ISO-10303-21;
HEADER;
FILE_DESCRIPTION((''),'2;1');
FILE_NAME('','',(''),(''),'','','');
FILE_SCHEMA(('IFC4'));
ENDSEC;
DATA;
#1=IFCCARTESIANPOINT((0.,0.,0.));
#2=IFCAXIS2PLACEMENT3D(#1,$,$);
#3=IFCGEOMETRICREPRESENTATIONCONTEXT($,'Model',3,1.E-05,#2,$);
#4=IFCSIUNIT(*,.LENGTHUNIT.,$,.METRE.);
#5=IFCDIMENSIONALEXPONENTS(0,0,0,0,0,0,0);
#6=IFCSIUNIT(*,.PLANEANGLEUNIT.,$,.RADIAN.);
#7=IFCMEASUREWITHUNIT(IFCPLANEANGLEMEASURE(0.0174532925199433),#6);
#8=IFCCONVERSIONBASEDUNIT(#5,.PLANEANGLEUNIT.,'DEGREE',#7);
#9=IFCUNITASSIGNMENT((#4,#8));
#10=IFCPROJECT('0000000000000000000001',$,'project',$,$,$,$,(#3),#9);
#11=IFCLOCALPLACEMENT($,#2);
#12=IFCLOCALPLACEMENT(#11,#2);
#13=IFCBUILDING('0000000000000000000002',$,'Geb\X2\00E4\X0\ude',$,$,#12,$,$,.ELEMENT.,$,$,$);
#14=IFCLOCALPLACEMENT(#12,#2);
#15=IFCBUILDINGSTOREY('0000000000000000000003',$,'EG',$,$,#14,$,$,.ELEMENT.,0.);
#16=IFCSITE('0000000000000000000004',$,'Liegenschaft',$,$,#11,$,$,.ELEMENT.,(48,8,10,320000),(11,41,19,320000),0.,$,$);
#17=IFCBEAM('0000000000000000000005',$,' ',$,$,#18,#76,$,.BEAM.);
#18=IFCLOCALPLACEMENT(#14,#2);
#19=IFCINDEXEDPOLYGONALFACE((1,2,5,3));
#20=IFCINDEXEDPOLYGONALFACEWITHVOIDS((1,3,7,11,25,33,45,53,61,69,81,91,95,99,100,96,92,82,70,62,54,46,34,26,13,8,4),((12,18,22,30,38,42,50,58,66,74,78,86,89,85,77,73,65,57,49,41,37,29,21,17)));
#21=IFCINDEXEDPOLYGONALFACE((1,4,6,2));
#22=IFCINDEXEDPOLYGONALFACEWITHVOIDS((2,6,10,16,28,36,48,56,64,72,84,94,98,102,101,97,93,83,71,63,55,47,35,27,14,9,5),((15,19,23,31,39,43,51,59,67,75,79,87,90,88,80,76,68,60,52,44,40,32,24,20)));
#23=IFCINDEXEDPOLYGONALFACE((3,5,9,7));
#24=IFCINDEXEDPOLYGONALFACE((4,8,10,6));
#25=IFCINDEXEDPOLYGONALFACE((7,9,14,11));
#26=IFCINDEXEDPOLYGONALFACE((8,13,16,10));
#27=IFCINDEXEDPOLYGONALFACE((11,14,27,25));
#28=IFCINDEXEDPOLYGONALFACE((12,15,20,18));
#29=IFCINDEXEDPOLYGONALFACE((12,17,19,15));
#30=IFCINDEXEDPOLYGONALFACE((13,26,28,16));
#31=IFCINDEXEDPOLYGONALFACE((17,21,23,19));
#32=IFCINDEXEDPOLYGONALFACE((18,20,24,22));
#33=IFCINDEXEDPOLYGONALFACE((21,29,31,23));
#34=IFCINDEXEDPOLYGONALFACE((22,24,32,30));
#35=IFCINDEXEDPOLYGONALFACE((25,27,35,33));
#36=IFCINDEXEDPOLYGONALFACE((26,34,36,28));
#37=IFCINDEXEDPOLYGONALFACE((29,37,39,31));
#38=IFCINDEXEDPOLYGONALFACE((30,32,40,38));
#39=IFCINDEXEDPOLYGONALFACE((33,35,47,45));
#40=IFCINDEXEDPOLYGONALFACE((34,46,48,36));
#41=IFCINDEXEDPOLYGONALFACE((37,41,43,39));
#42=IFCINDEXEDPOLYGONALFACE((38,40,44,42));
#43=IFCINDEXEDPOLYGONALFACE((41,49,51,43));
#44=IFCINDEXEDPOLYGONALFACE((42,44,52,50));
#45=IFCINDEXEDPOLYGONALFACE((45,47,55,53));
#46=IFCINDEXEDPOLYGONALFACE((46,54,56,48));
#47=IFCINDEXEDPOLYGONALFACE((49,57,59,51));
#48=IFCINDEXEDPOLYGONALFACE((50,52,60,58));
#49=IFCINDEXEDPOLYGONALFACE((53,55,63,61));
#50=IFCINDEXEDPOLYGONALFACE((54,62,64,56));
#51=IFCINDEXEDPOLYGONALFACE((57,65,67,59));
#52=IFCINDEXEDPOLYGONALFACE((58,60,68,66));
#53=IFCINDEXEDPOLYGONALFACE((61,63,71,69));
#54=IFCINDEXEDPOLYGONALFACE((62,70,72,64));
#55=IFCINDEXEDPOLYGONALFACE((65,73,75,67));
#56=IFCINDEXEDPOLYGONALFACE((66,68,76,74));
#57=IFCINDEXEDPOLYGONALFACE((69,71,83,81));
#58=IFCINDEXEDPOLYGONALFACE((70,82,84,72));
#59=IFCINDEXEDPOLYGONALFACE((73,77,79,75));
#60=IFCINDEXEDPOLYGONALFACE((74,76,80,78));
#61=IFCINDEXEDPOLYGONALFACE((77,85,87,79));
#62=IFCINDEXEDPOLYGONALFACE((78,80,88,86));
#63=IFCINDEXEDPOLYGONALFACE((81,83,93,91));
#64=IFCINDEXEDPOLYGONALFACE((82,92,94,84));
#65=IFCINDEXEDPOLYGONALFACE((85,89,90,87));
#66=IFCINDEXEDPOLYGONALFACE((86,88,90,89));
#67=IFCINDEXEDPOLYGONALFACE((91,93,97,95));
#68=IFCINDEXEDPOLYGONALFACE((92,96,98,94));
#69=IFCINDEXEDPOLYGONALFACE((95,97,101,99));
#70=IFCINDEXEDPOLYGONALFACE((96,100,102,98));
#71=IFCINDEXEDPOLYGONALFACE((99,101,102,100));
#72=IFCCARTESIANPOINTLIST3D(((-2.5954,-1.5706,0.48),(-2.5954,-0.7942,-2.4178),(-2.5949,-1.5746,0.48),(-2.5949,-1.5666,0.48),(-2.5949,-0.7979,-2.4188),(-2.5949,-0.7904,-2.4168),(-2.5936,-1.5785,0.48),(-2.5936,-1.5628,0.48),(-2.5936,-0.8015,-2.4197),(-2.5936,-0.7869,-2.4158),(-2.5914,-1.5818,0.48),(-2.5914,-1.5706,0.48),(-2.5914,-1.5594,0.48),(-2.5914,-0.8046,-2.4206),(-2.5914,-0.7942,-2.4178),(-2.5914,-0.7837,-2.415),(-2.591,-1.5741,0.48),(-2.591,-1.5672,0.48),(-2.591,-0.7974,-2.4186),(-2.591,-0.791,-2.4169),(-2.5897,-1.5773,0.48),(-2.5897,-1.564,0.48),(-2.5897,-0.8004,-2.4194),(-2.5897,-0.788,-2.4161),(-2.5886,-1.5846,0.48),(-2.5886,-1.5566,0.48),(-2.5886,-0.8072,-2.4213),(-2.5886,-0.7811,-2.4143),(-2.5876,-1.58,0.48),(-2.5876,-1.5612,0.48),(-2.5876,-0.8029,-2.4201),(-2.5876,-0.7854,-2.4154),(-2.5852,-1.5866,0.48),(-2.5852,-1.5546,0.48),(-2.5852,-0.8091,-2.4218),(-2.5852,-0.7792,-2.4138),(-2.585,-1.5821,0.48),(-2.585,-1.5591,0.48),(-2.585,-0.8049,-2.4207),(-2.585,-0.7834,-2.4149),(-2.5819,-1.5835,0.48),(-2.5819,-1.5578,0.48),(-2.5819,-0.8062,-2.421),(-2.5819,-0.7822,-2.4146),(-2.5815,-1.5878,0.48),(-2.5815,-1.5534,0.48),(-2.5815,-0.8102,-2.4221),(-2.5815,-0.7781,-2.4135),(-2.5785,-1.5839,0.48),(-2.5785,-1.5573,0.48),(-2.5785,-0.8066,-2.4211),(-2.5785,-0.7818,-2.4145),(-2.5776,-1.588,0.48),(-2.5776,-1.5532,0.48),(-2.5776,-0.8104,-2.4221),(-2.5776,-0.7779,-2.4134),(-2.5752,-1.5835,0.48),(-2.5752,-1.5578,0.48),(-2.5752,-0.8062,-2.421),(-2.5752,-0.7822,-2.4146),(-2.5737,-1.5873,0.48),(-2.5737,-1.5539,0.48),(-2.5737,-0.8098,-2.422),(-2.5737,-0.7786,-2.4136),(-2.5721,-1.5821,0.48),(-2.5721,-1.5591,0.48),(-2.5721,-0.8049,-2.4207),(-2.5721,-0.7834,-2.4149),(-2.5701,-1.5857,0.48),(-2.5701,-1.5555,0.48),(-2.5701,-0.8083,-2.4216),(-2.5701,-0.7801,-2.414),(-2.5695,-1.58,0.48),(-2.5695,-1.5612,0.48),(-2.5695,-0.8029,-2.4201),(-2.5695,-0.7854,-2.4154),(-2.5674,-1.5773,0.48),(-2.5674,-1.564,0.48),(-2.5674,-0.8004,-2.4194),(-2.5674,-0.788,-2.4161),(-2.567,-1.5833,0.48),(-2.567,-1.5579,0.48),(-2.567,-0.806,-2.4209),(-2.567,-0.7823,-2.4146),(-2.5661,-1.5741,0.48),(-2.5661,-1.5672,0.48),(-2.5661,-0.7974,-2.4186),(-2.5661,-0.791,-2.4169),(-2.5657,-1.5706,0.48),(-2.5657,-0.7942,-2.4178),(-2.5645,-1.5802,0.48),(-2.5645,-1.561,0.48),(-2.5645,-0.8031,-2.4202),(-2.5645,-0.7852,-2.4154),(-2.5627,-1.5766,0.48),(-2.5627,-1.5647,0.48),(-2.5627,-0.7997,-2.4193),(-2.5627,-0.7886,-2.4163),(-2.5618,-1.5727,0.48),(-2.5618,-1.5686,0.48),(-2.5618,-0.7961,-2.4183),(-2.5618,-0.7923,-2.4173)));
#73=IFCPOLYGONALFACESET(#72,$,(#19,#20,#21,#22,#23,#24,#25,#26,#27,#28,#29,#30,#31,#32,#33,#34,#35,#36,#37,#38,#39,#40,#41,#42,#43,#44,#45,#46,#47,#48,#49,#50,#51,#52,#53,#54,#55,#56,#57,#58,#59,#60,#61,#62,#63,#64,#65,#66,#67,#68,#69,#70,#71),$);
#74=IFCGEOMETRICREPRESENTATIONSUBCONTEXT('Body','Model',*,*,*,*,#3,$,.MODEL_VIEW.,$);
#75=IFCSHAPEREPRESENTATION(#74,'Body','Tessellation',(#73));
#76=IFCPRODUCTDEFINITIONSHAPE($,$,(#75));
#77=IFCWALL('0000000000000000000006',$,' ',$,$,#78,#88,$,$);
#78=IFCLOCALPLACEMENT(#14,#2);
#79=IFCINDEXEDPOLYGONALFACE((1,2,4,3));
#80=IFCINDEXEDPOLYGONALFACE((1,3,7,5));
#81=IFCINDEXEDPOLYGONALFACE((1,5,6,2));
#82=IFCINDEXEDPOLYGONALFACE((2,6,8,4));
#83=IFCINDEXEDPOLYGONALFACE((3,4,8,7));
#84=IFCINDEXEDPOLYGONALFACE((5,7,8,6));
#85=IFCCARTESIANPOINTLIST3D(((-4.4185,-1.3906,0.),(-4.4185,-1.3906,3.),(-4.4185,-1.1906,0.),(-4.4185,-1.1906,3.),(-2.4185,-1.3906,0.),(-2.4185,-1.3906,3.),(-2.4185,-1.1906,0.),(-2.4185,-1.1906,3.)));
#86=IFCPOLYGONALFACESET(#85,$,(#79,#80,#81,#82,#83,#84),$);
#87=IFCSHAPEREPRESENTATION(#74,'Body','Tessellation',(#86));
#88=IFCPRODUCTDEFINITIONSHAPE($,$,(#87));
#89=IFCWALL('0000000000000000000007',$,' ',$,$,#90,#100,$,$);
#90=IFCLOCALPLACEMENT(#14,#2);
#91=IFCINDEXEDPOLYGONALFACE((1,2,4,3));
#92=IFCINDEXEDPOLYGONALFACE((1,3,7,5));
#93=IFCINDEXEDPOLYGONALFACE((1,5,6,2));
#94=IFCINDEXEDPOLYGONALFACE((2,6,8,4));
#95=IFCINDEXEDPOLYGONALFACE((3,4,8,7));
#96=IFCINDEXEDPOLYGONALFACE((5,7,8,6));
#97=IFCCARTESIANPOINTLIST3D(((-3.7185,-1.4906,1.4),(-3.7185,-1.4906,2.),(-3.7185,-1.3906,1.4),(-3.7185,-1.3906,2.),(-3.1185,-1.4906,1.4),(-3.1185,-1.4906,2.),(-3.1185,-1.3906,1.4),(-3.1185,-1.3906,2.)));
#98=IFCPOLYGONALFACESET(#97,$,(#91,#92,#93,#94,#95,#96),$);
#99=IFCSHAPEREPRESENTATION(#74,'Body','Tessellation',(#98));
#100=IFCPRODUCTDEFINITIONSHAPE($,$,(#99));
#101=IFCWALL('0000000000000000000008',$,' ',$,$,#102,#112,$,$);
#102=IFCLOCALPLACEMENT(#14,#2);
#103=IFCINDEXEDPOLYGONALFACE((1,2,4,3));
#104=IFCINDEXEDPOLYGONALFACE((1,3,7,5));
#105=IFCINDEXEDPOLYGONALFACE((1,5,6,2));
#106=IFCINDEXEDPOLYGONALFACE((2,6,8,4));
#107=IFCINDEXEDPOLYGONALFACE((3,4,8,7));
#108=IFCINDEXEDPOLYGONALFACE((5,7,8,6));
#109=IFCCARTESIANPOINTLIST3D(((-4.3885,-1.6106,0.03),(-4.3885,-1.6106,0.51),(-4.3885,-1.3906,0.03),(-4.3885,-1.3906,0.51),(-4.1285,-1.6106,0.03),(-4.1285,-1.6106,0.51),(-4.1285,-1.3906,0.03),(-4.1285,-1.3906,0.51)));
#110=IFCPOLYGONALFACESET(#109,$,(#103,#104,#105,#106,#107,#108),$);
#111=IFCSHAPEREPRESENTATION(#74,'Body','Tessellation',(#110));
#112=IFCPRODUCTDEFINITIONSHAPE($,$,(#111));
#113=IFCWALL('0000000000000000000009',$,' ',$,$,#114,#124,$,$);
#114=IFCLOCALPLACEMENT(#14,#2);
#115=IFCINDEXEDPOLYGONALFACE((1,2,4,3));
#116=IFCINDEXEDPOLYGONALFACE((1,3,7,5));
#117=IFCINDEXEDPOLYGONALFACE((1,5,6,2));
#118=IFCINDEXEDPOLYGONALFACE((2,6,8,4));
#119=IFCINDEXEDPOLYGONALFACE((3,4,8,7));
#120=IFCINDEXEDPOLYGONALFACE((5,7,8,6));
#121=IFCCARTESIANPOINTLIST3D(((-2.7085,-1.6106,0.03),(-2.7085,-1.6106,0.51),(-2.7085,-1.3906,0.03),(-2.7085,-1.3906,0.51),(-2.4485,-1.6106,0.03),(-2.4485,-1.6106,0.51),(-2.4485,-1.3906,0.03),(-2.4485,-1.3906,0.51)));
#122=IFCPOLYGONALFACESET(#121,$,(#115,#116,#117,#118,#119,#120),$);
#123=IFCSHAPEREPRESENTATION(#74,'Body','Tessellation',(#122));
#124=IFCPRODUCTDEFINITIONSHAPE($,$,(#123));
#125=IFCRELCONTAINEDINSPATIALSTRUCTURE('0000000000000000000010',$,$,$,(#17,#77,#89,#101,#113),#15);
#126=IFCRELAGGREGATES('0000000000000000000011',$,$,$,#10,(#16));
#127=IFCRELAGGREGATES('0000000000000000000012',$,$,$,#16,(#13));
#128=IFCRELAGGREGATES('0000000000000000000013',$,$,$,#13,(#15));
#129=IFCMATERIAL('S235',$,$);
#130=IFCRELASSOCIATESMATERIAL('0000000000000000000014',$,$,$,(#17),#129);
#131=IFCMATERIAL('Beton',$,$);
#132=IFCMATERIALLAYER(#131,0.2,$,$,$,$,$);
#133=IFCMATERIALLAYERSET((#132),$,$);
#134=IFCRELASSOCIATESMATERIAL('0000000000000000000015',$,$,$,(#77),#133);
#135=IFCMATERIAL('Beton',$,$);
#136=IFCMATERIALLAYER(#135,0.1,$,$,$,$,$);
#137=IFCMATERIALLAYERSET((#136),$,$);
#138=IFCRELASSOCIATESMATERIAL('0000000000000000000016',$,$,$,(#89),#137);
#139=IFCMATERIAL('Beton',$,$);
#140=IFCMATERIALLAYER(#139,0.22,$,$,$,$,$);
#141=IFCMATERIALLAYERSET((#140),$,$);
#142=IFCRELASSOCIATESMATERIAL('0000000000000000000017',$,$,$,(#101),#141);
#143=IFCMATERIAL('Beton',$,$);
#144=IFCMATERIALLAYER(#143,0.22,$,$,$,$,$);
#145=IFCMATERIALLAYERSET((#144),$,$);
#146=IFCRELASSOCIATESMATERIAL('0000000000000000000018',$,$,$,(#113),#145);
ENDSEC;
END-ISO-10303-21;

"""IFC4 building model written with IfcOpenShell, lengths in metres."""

from ifc_helpers import new_model, entity, si_unit, converted_unit, frame, frame_2d, origin, origin_with_axes, place, context, subcontext, project, spatial, polyline, rectangle, outline, extrude, clip, halfspace, material, layer, layer_set, layer_usage, element, save


model = new_model("IFC4")

# Units and contexts
model_context = context("Model", 3, precision=1e-05, world=origin())
body_context = subcontext(model_context, "Body", "Model", "MODEL_VIEW")
ifc_project = project(units=[si_unit("LENGTHUNIT", "METRE"), converted_unit("PLANEANGLEUNIT", "DEGREE", entity("IfcPlaneAngleMeasure", 0.0174532925199433), si_unit("PLANEANGLEUNIT", "RADIAN"), dimensions=[0, 0, 0, 0, 0, 0, 0])], contexts=[model_context])

# Site, building, storey
site_placement = place(None, origin())
site = spatial("IfcSite", under=ifc_project, at=site_placement, Name="Liegenschaft", CompositionType="ELEMENT", RefLatitude=(48, 8, 10, 320000), RefLongitude=(11, 41, 19, 320000), RefElevation=0.0)
building_placement = place(site_placement, origin())
building = spatial("IfcBuilding", under=site, at=building_placement, Name="Gebäude", CompositionType="ELEMENT")
storey_placement = place(building_placement, origin())
storey = spatial("IfcBuildingStorey", under=building, at=storey_placement, Name="EG", CompositionType="ELEMENT", Elevation=0.0)

# Beam
ifc_material_1 = material(Name="S235")
beam_1_placement = place(storey_placement, frame((-2.5785, -1.5718, 0.4844)))
element("IfcBeam", 1, at=beam_1_placement, inside=storey, material=ifc_material_1, Name=" ", PredefinedType="BEAM", context=body_context, shape_type="Clipping", body=[
    clip(extrude(outline(polyline([(0.0168, 0.0), (0.0164, 0.0039), (0.0151, 0.0076), (0.0129, 0.0108), (0.0101, 0.0135), (0.0067, 0.0155), (0.0029, 0.0166), (-0.001, 0.0168), (-0.0048, 0.0161), (-0.0084, 0.0146), (-0.0116, 0.0123), (-0.0141, 0.0093), (-0.0158, 0.0058), (-0.0167, 0.002), (-0.0167, -0.002), (-0.0158, -0.0058), (-0.0141, -0.0093), (-0.0116, -0.0123), (-0.0084, -0.0146), (-0.0048, -0.0161), (-0.001, -0.0168), (0.0029, -0.0166), (0.0067, -0.0155), (0.0101, -0.0135), (0.0129, -0.0108), (0.0151, -0.0076), (0.0164, -0.0039), (0.0168, 0.0)]), holes=[polyline([(-0.0129, 0.0), (-0.0124, 0.0033), (-0.0111, 0.0064), (-0.0091, 0.0091), (-0.0064, 0.0111), (-0.0033, 0.0124), (0.0, 0.0129), (0.0033, 0.0124), (0.0064, 0.0111), (0.0091, 0.0091), (0.0111, 0.0064), (0.0124, 0.0033), (0.0128, 0.0), (0.0124, -0.0033), (0.0111, -0.0064), (0.0091, -0.0091), (0.0064, -0.0111), (0.0033, -0.0124), (0.0, -0.0128), (-0.0033, -0.0124), (-0.0064, -0.0111), (-0.0091, -0.0091), (-0.0111, -0.0064), (-0.0124, -0.0033), (-0.0129, 0.0)])]), frame((0.0, 0.0, 0.0), z_axis=(0.0, 0.258819, -0.965926), x_axis=(-1.0, 0.0, 0.0)), (0.0, 0.0, 1.0), 3.0045), halfspace(frame((0.0, 0.0012, -0.0044), z_axis=(0.0, 0.0, -1.0), x_axis=(1.0, 0.0, 0.0)), True)),
])

# Walls
ifc_material_2 = material(Name="Beton")
ifc_layer_1 = layer(ifc_material_2, 0.2)
ifc_layer_set_1 = layer_set([ifc_layer_1])
ifc_layer_usage_1 = layer_usage(ifc_layer_set_1, "AXIS2", "POSITIVE", 0.0)
wall_1_placement = place(storey_placement, frame((-2.4185, -1.1906, 0.0), z_axis=(0.0, 0.0, 1.0), x_axis=(-1.0, 0.0, 0.0)))
element("IfcWall", 2, at=wall_1_placement, inside=storey, material=ifc_layer_usage_1, Name=" ", context=body_context, shape_type="SweptSolid", body=[
    extrude(rectangle(XDim=2.0, YDim=0.2, at=frame_2d((1.0, 0.1), x_axis=(1.0, 0.0))), origin_with_axes(), (0.0, 0.0, 1.0), 3.0),
])
ifc_material_3 = material(Name="Beton")
ifc_layer_2 = layer(ifc_material_3, 0.1)
ifc_layer_set_2 = layer_set([ifc_layer_2])
ifc_layer_usage_2 = layer_usage(ifc_layer_set_2, "AXIS2", "POSITIVE", 0.0)
wall_2_placement = place(storey_placement, frame((-3.1185, -1.3906, 1.4), z_axis=(0.0, 0.0, 1.0), x_axis=(-1.0, 0.0, 0.0)))
element("IfcWall", 3, at=wall_2_placement, inside=storey, material=ifc_layer_usage_2, Name=" ", context=body_context, shape_type="SweptSolid", body=[
    extrude(rectangle(XDim=0.6, YDim=0.1, at=frame_2d((0.3, 0.05), x_axis=(1.0, 0.0))), origin_with_axes(), (0.0, 0.0, 1.0), 0.6),
])
ifc_material_4 = material(Name="Beton")
ifc_layer_3 = layer(ifc_material_4, 0.22)
ifc_layer_set_3 = layer_set([ifc_layer_3])
ifc_layer_usage_3 = layer_usage(ifc_layer_set_3, "AXIS2", "POSITIVE", 0.0)
wall_3_placement = place(storey_placement, frame((-4.1285, -1.3906, 0.03), z_axis=(0.0, 0.0, 1.0), x_axis=(-1.0, 0.0, 0.0)))
element("IfcWall", 4, at=wall_3_placement, inside=storey, material=ifc_layer_usage_3, Name=" ", context=body_context, shape_type="SweptSolid", body=[
    extrude(rectangle(XDim=0.26, YDim=0.22, at=frame_2d((0.13, 0.11), x_axis=(1.0, 0.0))), origin_with_axes(), (0.0, 0.0, 1.0), 0.48),
])
ifc_material_5 = material(Name="Beton")
ifc_layer_4 = layer(ifc_material_5, 0.22)
ifc_layer_set_4 = layer_set([ifc_layer_4])
ifc_layer_usage_4 = layer_usage(ifc_layer_set_4, "AXIS2", "POSITIVE", 0.0)
wall_4_placement = place(storey_placement, frame((-2.4485, -1.3906, 0.03), z_axis=(0.0, 0.0, 1.0), x_axis=(-1.0, 0.0, 0.0)))
element("IfcWall", 5, at=wall_4_placement, inside=storey, material=ifc_layer_usage_4, Name=" ", context=body_context, shape_type="SweptSolid", body=[
    extrude(rectangle(XDim=0.26, YDim=0.22, at=frame_2d((0.13, 0.11), x_axis=(1.0, 0.0))), origin_with_axes(), (0.0, 0.0, 1.0), 0.48),
])

save(model, "model.ifc")
